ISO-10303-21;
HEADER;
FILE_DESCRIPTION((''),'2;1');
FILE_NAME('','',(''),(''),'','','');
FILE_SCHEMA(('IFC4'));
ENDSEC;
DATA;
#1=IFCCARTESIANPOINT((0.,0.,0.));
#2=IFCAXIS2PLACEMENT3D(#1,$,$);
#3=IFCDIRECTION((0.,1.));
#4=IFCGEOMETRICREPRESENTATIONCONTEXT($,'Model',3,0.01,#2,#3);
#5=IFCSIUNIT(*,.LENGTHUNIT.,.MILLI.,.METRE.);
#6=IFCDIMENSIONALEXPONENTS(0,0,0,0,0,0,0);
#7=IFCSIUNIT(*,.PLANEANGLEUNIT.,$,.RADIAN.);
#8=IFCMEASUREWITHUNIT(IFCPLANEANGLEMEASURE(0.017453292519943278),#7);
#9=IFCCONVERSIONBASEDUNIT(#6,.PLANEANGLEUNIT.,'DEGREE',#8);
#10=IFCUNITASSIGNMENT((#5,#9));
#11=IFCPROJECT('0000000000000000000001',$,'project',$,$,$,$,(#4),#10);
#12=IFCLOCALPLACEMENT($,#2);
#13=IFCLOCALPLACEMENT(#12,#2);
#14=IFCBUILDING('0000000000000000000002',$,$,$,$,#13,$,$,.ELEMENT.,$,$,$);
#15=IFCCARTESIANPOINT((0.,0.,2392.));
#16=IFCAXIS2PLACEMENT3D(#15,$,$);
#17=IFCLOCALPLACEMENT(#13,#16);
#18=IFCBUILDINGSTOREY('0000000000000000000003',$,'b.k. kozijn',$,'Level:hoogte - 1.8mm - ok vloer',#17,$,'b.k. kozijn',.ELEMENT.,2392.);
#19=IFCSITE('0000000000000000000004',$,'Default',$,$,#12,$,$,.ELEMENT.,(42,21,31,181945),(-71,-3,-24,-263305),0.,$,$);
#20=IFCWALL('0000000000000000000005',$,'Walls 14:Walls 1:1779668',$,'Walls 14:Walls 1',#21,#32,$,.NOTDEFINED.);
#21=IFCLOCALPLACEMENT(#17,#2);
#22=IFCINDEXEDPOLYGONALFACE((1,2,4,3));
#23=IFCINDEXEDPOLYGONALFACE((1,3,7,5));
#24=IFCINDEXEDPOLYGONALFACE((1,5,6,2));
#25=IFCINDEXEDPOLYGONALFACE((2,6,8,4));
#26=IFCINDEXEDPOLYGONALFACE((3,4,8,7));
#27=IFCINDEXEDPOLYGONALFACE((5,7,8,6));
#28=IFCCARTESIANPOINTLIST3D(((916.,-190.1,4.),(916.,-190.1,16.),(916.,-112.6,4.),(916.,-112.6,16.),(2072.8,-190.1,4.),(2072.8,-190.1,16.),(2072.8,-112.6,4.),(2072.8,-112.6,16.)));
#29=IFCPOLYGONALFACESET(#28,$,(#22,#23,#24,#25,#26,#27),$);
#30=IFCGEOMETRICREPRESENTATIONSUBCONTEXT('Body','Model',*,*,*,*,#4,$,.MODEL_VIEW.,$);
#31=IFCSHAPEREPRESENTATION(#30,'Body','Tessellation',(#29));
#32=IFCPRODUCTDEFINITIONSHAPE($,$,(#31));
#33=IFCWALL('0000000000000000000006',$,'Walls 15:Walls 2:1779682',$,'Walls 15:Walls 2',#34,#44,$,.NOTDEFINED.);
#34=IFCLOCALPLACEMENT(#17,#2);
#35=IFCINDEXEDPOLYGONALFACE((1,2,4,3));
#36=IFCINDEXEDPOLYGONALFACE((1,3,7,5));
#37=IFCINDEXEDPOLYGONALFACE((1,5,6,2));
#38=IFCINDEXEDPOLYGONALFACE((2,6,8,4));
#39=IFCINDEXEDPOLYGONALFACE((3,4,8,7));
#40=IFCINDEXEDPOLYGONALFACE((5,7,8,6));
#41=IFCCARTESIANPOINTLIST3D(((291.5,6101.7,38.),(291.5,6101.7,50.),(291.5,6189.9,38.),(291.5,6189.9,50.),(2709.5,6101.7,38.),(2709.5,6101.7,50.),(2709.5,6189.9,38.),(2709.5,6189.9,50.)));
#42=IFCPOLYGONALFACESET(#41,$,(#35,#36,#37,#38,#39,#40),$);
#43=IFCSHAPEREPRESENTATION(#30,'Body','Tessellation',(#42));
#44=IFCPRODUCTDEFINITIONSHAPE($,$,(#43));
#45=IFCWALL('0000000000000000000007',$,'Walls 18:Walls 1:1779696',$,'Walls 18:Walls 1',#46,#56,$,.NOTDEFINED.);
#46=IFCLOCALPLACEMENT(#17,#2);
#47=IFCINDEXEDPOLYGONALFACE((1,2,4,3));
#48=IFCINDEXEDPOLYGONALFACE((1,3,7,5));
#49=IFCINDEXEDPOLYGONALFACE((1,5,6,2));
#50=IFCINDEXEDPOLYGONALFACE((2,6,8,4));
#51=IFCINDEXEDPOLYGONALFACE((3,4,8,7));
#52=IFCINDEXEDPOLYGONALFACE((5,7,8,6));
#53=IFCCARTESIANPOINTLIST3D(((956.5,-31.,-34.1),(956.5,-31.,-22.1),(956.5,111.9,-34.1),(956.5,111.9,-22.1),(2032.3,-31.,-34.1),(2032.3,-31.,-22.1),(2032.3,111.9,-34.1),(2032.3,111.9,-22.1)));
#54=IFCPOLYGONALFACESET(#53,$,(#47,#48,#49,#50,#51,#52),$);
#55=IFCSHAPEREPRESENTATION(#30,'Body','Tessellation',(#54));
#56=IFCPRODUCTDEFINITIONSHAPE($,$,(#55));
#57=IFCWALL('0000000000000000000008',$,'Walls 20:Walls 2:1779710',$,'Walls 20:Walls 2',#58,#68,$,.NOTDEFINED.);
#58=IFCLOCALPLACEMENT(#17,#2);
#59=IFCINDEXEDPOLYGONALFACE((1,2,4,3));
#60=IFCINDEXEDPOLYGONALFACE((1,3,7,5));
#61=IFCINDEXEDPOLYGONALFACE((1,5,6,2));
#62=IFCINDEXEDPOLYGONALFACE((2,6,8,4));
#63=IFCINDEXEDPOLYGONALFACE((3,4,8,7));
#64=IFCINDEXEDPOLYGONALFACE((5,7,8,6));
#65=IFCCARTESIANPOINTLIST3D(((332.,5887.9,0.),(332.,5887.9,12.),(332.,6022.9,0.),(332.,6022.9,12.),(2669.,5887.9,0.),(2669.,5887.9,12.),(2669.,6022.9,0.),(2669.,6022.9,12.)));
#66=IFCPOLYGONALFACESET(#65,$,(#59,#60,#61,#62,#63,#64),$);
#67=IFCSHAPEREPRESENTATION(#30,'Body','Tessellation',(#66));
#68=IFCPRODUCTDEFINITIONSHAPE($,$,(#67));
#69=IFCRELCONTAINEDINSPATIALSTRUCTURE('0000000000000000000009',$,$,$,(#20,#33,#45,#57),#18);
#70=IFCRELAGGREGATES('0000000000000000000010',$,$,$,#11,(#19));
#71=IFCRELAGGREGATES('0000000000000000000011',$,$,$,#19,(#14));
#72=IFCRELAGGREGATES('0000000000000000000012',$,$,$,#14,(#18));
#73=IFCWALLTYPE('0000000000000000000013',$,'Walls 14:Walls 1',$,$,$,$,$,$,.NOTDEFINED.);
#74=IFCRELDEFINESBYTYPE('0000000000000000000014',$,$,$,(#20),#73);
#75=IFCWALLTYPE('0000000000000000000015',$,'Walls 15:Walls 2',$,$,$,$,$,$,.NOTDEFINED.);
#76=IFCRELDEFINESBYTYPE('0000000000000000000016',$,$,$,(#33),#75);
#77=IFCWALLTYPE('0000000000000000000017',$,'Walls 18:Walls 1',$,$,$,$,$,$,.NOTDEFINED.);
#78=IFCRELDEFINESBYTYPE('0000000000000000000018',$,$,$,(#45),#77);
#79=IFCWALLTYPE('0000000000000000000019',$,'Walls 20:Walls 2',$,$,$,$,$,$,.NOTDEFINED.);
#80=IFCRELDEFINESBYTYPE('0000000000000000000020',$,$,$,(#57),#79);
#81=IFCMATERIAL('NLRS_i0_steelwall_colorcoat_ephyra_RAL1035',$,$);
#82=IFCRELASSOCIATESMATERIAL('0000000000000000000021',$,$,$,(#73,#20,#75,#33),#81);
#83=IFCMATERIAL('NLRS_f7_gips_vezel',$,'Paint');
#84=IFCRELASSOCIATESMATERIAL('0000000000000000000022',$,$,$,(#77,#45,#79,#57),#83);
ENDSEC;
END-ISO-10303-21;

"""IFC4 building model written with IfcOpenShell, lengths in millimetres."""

from ifc_helpers import new_model, entity, si_unit, converted_unit, direction, frame, origin, place, context, subcontext, project, spatial, indexed_curve, outline, extrude, material, type_object, element, save


model = new_model("IFC4")

# Units and contexts
model_context = context("Model", 3, precision=0.01, world=origin(), true_north=direction((0.0, 1.0)))
body_context = subcontext(model_context, "Body", "Model", "MODEL_VIEW")
ifc_project = project(units=[si_unit("LENGTHUNIT", "METRE", prefix="MILLI"), converted_unit("PLANEANGLEUNIT", "DEGREE", entity("IfcPlaneAngleMeasure", 0.017453292519943278), si_unit("PLANEANGLEUNIT", "RADIAN"), dimensions=[0, 0, 0, 0, 0, 0, 0])], contexts=[model_context])

# Site, building, storey
site_placement = place(None, origin())
site = spatial("IfcSite", under=ifc_project, at=site_placement, Name="Default", CompositionType="ELEMENT", RefLatitude=(42, 21, 31, 181945), RefLongitude=(-71, -3, -24, -263305), RefElevation=0.0)
building_placement = place(site_placement, origin())
building = spatial("IfcBuilding", under=site, at=building_placement, CompositionType="ELEMENT")
storey_placement = place(building_placement, frame((0.0, 0.0, 2392.0)))
storey = spatial("IfcBuildingStorey", under=building, at=storey_placement, Name="b.k. kozijn", ObjectType="Level:hoogte - 1.8mm - ok vloer", LongName="b.k. kozijn", CompositionType="ELEMENT", Elevation=2392.0)

# Walls
ifc_material_1 = material(Name="NLRS_i0_steelwall_colorcoat_ephyra_RAL1035")
wall_type_1 = type_object("IfcWallType", Name="Walls 14:Walls 1", PredefinedType="NOTDEFINED", material=ifc_material_1)
wall_1_placement = place(storey_placement, frame((916.0, -190.1, 4.0)))
element("IfcWall", 1, at=wall_1_placement, inside=storey, type_object=wall_type_1, material=ifc_material_1, Name="Walls 14:Walls 1:1779668", ObjectType="Walls 14:Walls 1", PredefinedType="NOTDEFINED", context=body_context, shape_type="SweptSolid", body=[
    extrude(outline(indexed_curve([(-38.7, -578.4), (38.7, -578.4), (38.7, 578.4), (-38.7, 578.4), (-38.7, -578.4)], self_intersect=False)), frame((578.4, 38.7, 0.0), z_axis=(0.0, 0.0, 1.0), x_axis=(0.0, 1.0, 0.0)), (0.0, 0.0, 1.0), 12.0),
])
wall_type_2 = type_object("IfcWallType", Name="Walls 15:Walls 2", PredefinedType="NOTDEFINED", material=ifc_material_1)
wall_2_placement = place(storey_placement, frame((291.5, 6101.7, 38.0)))
element("IfcWall", 2, at=wall_2_placement, inside=storey, type_object=wall_type_2, material=ifc_material_1, Name="Walls 15:Walls 2:1779682", ObjectType="Walls 15:Walls 2", PredefinedType="NOTDEFINED", context=body_context, shape_type="SweptSolid", body=[
    extrude(outline(indexed_curve([(-44.1, -1209.0), (44.1, -1209.0), (44.1, 1209.0), (-44.1, 1209.0), (-44.1, -1209.0)], self_intersect=False)), frame((1209.0, 44.1, 0.0), z_axis=(0.0, 0.0, 1.0), x_axis=(0.0, 1.0, 0.0)), (0.0, 0.0, 1.0), 12.0),
])
ifc_material_2 = material(Name="NLRS_f7_gips_vezel", Category="Paint")
wall_type_3 = type_object("IfcWallType", Name="Walls 18:Walls 1", PredefinedType="NOTDEFINED", material=ifc_material_2)
wall_3_placement = place(storey_placement, frame((956.5, -31.0, -34.1)))
element("IfcWall", 3, at=wall_3_placement, inside=storey, type_object=wall_type_3, material=ifc_material_2, Name="Walls 18:Walls 1:1779696", ObjectType="Walls 18:Walls 1", PredefinedType="NOTDEFINED", context=body_context, shape_type="SweptSolid", body=[
    extrude(outline(indexed_curve([(-71.5, -537.9), (71.5, -537.9), (71.5, 537.9), (-71.5, 537.9), (-71.5, -537.9)], self_intersect=False)), frame((537.9, 71.5, 0.0), z_axis=(0.0, 0.0, 1.0), x_axis=(0.0, 1.0, 0.0)), (0.0, 0.0, 1.0), 12.0),
])
wall_type_4 = type_object("IfcWallType", Name="Walls 20:Walls 2", PredefinedType="NOTDEFINED", material=ifc_material_2)
wall_4_placement = place(storey_placement, frame((332.0, 5887.9, 0.0)))
element("IfcWall", 4, at=wall_4_placement, inside=storey, type_object=wall_type_4, material=ifc_material_2, Name="Walls 20:Walls 2:1779710", ObjectType="Walls 20:Walls 2", PredefinedType="NOTDEFINED", context=body_context, shape_type="SweptSolid", body=[
    extrude(outline(indexed_curve([(-67.5, -1168.5), (67.5, -1168.5), (67.5, 1168.5), (-67.5, 1168.5), (-67.5, -1168.5)], self_intersect=False)), frame((1168.5, 67.5, 0.0), z_axis=(0.0, 0.0, 1.0), x_axis=(0.0, 1.0, 0.0)), (0.0, 0.0, 1.0), 12.0),
])

save(model, "model.ifc")
